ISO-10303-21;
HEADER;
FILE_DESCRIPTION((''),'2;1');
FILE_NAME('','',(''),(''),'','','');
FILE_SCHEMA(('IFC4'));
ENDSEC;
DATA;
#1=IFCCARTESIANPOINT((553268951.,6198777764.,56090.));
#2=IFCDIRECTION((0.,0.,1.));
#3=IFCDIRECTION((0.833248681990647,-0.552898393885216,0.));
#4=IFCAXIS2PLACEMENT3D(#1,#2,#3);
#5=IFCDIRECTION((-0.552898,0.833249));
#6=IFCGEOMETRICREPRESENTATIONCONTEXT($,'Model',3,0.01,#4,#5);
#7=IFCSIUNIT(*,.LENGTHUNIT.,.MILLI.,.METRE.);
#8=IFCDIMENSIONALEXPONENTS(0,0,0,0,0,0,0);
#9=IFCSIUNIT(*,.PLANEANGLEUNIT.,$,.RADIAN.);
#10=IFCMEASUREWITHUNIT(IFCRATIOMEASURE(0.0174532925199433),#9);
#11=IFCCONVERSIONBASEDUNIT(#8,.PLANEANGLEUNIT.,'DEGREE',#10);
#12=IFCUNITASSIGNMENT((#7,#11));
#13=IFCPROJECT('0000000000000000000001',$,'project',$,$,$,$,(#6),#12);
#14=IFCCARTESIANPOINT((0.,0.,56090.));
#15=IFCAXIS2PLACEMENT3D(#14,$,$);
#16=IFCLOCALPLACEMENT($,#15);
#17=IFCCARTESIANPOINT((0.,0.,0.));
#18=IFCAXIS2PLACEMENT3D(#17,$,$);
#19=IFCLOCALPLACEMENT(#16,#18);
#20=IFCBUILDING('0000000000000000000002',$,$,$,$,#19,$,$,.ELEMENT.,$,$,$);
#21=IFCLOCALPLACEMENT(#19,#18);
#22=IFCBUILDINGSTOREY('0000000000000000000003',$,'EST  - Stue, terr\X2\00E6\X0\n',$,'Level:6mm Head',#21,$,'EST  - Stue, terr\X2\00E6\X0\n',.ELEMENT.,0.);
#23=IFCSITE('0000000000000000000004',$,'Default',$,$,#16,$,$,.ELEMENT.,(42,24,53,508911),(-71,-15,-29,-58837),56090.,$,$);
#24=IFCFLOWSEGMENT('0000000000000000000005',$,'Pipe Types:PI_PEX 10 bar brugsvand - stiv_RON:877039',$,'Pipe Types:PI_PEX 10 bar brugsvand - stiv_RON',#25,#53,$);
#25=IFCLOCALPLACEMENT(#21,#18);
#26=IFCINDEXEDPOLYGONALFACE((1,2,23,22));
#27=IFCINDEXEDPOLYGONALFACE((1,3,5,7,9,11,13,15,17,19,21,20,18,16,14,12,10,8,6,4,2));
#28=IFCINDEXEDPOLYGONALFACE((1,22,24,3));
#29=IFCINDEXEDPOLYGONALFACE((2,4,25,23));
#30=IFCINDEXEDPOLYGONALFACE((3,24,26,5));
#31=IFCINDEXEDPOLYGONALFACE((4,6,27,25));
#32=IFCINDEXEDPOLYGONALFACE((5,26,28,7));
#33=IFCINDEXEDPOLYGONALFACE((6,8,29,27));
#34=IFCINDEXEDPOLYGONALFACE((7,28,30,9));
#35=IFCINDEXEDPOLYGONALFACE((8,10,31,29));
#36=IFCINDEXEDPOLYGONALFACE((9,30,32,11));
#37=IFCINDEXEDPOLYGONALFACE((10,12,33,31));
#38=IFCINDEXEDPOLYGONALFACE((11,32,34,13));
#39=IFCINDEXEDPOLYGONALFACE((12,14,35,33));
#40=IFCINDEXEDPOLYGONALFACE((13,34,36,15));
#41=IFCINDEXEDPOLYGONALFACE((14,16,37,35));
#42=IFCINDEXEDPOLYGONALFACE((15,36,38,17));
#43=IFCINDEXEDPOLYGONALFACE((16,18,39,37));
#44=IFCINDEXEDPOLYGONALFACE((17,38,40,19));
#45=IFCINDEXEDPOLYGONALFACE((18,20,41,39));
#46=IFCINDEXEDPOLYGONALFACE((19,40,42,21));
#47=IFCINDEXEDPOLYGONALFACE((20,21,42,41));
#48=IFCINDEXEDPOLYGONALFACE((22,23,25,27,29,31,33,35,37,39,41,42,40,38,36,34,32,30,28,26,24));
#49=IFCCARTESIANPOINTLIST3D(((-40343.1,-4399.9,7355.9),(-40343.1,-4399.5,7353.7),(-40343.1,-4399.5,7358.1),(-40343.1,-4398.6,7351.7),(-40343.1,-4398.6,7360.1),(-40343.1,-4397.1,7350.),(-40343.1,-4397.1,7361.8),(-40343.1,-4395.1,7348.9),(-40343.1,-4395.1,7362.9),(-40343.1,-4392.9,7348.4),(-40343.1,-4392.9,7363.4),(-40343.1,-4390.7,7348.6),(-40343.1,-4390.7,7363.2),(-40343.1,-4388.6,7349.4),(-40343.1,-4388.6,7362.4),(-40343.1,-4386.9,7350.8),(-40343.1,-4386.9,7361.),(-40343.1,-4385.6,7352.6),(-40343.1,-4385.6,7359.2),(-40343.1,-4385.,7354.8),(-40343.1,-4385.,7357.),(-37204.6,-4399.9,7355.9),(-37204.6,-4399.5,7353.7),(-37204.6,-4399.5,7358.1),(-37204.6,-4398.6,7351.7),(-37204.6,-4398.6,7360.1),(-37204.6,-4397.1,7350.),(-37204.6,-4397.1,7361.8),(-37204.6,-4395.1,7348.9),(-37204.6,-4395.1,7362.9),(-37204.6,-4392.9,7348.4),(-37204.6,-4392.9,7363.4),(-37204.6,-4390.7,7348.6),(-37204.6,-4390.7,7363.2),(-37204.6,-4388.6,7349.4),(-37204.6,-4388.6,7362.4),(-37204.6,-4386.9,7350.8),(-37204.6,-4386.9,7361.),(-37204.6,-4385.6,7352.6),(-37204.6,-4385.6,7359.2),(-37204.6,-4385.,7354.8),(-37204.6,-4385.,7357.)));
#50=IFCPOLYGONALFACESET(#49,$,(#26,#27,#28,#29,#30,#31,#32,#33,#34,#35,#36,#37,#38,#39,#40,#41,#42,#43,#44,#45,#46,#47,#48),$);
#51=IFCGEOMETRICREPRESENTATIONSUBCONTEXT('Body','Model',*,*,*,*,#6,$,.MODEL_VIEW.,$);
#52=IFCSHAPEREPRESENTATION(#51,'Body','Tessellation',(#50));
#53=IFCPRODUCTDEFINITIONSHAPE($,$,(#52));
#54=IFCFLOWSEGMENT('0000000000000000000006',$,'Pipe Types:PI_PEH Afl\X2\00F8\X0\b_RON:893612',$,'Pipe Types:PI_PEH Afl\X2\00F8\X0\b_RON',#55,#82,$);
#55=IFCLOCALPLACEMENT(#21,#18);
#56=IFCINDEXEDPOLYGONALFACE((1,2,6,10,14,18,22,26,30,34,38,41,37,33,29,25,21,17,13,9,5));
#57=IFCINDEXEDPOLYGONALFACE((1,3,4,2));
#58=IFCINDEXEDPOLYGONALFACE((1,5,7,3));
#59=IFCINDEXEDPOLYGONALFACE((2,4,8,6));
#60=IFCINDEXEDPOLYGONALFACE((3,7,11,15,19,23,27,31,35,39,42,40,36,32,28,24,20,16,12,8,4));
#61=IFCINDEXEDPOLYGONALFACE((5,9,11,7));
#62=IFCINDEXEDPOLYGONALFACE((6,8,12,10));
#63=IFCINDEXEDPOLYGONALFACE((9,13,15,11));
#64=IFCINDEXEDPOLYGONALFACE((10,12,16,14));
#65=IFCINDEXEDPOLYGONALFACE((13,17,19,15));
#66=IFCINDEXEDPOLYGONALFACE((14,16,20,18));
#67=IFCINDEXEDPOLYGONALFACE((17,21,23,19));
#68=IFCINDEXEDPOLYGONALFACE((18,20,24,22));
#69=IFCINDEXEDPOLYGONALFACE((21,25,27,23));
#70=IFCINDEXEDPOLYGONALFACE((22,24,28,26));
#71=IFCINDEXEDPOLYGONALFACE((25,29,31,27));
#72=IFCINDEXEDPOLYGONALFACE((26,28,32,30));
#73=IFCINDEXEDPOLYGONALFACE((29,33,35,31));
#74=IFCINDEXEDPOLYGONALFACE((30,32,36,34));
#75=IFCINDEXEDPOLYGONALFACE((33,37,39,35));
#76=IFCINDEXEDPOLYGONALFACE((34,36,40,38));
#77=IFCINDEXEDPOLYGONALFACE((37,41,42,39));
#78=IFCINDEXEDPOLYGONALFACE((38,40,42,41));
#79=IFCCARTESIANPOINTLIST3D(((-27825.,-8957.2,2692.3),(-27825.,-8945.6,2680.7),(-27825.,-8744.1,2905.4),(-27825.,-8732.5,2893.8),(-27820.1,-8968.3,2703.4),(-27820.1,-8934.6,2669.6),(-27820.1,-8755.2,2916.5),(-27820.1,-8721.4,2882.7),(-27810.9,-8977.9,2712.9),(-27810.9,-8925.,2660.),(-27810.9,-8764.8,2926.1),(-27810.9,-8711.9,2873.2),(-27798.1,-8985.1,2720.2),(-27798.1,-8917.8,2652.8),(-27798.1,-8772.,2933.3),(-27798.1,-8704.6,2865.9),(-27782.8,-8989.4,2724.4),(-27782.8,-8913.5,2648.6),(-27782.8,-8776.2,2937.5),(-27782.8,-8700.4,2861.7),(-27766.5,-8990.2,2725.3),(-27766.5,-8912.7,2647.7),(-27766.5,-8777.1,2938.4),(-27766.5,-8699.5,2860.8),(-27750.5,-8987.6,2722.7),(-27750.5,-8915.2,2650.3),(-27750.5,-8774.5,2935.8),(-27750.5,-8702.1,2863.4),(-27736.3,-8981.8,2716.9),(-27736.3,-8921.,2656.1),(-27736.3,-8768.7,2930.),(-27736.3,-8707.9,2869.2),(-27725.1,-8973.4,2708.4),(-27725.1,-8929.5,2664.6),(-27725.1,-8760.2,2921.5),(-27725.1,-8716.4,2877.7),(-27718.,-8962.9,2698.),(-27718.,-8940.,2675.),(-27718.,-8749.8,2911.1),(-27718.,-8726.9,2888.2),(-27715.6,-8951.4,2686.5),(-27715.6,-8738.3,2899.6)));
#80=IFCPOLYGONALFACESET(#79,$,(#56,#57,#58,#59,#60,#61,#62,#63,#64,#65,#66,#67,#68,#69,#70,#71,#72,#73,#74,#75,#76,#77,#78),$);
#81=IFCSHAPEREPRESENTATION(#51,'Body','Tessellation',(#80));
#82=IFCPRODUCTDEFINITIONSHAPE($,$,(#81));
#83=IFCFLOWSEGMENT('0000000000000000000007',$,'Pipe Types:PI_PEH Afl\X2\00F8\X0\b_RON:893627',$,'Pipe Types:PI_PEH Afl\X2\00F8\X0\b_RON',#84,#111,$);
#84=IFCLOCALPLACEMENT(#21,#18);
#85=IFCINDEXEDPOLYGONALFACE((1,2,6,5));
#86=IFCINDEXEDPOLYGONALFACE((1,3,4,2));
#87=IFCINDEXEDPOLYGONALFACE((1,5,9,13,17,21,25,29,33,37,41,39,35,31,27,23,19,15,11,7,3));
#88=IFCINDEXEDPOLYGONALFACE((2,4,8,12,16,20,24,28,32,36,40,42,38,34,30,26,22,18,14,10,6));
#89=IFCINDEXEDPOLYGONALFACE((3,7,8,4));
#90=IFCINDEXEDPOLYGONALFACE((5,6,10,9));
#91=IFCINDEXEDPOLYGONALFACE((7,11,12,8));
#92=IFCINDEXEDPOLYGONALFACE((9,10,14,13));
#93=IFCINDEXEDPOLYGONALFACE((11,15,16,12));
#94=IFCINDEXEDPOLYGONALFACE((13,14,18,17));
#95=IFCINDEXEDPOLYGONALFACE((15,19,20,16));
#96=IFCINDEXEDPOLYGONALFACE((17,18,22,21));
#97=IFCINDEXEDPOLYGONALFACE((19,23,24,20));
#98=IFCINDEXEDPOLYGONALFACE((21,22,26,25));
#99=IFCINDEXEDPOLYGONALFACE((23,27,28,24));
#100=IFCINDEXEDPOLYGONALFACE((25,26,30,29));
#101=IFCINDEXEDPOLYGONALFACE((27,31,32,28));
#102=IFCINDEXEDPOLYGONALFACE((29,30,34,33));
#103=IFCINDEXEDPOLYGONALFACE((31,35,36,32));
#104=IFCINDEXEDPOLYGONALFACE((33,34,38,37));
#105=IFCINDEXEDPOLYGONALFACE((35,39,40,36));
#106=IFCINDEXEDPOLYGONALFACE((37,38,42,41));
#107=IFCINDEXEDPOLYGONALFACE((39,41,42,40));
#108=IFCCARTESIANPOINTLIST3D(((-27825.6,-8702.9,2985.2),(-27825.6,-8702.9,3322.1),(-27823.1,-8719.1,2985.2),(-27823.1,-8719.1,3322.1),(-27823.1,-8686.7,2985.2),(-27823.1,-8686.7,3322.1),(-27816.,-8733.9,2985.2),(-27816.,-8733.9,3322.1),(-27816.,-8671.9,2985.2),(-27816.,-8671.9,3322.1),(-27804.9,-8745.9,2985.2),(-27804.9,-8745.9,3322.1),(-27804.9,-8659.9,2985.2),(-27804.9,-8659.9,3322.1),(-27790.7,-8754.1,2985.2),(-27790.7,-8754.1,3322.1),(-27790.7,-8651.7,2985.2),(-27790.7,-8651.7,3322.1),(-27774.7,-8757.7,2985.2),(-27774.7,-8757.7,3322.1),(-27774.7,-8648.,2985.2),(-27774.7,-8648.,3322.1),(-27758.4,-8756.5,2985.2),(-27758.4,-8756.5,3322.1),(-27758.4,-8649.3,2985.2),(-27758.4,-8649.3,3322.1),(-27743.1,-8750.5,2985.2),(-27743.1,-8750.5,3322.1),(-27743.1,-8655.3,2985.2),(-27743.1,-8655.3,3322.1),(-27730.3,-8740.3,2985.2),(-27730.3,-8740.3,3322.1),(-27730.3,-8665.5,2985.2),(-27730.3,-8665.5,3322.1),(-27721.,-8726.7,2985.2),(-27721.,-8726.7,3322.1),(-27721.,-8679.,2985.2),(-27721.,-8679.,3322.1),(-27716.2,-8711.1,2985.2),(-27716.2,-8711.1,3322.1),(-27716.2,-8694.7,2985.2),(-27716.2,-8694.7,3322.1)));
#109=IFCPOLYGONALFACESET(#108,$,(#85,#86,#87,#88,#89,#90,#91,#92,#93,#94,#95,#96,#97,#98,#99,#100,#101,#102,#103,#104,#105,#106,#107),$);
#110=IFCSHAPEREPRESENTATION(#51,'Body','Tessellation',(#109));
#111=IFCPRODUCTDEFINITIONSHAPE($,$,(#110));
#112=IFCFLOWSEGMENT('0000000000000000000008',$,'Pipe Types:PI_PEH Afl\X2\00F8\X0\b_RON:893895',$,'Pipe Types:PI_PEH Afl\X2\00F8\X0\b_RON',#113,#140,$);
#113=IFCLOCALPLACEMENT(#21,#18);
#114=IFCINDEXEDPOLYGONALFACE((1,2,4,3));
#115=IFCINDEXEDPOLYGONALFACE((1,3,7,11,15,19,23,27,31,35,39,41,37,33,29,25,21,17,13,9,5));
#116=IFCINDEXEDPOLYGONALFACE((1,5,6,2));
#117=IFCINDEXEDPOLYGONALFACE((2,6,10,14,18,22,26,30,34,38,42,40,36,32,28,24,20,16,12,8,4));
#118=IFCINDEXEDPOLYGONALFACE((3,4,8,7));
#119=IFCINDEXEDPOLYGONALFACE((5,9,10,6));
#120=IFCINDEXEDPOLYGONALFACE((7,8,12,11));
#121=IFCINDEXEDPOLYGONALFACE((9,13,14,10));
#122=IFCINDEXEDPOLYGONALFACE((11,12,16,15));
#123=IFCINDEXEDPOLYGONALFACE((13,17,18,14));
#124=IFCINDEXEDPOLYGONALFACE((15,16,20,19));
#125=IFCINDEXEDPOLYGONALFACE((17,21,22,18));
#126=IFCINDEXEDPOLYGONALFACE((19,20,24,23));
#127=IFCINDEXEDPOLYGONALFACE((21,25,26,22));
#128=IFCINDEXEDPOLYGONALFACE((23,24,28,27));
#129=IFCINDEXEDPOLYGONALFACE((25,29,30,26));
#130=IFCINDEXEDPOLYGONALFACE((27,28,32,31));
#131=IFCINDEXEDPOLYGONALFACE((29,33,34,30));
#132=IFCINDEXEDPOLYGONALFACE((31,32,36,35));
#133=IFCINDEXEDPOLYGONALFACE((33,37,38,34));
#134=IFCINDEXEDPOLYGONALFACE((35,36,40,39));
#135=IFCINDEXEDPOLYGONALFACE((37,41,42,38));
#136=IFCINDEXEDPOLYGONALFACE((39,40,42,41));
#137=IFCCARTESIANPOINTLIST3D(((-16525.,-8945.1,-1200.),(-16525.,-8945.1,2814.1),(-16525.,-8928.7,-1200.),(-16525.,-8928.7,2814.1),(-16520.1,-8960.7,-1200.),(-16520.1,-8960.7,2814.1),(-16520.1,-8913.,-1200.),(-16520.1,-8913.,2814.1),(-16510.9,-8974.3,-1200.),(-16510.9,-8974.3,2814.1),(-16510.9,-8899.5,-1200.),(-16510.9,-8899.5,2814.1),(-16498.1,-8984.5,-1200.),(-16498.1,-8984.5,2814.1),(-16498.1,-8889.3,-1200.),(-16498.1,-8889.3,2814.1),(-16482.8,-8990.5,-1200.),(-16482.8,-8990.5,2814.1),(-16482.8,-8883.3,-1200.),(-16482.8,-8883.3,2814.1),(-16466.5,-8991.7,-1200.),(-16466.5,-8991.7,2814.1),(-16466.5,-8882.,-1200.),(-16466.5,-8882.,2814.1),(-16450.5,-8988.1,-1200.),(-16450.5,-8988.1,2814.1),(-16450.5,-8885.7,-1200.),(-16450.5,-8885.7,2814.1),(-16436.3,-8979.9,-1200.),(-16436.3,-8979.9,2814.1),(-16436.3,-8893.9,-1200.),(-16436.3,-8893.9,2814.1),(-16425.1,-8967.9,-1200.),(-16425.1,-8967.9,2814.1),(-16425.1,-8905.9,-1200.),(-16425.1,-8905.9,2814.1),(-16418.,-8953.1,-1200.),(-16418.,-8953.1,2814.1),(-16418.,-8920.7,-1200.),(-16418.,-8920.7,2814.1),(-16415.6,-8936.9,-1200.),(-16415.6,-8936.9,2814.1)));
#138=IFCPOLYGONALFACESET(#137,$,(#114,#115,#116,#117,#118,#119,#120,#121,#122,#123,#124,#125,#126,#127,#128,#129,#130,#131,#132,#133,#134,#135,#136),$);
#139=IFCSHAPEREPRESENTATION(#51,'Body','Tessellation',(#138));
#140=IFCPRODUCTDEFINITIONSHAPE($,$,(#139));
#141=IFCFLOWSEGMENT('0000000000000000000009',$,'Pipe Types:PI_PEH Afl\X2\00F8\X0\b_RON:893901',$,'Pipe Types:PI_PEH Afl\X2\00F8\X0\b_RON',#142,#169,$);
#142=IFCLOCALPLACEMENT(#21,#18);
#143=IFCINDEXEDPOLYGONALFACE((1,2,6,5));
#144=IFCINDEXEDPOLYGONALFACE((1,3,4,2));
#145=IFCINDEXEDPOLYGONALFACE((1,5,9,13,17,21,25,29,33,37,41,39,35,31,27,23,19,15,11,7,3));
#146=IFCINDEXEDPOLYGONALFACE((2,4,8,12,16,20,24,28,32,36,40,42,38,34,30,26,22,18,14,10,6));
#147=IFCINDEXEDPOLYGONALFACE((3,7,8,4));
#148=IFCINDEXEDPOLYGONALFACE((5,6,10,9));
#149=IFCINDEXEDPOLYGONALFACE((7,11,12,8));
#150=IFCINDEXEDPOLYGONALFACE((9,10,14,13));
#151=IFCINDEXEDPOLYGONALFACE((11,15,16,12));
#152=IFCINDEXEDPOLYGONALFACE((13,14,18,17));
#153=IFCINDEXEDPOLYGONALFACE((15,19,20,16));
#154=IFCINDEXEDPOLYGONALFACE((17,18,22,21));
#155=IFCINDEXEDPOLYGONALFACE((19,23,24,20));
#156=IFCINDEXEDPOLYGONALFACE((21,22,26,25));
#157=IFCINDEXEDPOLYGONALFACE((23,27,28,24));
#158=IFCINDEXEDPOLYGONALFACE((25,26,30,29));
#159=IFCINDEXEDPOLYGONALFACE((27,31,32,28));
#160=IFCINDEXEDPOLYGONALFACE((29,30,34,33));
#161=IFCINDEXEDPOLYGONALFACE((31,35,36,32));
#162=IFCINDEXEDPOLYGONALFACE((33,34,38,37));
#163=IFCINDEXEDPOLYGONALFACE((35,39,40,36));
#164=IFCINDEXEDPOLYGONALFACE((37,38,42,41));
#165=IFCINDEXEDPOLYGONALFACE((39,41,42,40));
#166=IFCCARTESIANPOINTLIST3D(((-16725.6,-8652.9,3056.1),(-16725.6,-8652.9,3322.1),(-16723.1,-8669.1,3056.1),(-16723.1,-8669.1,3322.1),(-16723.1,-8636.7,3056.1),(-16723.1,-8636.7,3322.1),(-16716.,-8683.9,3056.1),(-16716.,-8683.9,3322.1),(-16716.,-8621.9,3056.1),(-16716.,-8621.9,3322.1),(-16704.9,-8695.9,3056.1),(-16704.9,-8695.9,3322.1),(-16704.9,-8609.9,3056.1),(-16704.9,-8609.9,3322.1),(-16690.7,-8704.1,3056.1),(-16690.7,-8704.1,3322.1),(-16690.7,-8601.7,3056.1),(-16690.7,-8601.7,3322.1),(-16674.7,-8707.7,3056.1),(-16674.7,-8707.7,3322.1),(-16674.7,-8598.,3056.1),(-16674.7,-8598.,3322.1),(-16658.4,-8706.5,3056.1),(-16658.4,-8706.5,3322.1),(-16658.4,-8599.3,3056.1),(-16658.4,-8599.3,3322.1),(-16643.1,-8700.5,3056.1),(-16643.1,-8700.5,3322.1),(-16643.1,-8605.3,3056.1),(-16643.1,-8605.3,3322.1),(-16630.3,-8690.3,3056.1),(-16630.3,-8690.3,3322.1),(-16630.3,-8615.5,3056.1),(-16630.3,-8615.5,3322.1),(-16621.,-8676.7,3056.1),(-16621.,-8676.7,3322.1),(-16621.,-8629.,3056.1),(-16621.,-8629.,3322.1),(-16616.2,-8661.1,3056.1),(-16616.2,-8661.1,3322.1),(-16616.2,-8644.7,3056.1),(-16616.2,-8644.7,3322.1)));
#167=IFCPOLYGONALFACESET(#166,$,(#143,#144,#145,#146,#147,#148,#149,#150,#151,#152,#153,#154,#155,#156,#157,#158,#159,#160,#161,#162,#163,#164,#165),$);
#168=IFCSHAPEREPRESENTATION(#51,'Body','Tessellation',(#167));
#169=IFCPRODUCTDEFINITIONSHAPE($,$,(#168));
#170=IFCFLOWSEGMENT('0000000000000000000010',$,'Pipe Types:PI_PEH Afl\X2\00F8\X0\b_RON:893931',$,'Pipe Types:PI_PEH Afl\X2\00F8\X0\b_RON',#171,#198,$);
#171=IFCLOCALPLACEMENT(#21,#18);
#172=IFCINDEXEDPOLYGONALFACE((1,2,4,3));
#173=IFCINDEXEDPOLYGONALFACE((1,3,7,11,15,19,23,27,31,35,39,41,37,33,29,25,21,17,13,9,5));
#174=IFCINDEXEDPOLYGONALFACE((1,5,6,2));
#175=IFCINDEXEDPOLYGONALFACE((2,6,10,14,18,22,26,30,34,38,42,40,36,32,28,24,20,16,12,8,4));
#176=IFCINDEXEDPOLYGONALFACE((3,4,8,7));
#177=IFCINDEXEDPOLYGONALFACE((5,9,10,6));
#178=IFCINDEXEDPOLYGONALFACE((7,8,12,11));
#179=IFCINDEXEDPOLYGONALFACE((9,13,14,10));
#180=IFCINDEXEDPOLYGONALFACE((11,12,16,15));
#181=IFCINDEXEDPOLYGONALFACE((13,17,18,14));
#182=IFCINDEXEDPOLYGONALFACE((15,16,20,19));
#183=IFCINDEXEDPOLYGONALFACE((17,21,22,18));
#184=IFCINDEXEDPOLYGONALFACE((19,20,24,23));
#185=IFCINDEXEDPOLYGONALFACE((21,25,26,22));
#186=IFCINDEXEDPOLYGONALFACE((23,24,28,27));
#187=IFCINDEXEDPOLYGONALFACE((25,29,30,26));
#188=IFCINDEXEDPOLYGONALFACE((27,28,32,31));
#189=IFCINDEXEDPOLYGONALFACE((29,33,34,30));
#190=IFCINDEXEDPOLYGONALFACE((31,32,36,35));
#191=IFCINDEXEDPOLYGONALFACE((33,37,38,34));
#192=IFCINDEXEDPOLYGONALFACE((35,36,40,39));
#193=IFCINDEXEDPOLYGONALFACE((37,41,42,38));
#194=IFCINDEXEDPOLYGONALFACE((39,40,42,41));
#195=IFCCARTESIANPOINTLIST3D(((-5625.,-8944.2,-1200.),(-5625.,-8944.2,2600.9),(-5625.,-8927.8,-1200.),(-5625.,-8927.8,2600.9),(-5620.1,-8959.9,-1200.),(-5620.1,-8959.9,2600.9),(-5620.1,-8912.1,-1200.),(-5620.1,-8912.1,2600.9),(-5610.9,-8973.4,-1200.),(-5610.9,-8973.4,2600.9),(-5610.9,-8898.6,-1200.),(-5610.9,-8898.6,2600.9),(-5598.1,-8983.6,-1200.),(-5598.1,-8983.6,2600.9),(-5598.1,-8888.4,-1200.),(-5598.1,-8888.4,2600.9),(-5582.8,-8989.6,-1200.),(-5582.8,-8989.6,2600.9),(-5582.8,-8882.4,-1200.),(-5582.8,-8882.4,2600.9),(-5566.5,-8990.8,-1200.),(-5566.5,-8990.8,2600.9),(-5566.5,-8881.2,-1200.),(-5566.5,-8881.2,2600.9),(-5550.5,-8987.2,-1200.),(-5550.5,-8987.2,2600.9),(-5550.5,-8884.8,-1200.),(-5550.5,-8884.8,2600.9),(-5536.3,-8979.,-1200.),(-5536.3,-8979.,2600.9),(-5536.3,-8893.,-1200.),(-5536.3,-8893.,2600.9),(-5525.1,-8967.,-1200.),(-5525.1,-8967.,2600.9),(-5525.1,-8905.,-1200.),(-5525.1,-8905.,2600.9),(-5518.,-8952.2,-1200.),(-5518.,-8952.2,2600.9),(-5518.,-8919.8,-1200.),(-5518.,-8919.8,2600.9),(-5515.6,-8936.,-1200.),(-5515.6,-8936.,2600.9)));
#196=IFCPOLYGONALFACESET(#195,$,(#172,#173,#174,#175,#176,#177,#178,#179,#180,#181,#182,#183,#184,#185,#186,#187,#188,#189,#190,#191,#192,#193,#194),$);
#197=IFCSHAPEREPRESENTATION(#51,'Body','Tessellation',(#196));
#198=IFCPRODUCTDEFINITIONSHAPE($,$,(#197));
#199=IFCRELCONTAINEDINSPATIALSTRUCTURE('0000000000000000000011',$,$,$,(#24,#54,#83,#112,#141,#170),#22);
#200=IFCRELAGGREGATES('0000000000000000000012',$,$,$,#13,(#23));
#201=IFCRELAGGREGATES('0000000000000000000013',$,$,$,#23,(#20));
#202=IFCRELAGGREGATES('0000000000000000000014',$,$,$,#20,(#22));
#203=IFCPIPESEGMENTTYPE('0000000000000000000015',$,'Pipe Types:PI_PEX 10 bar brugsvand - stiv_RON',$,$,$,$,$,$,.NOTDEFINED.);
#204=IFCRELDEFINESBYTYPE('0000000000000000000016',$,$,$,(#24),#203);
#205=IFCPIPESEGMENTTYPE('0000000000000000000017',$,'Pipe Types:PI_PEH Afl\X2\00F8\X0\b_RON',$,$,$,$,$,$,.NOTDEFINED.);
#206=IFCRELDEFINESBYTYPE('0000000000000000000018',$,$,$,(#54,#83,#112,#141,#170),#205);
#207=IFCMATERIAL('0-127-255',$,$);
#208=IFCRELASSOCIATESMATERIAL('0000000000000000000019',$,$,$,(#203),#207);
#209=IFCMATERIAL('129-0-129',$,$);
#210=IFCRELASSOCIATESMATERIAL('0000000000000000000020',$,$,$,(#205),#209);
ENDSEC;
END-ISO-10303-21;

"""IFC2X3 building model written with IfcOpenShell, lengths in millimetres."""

from ifc_helpers import new_model, entity, si_unit, converted_unit, direction, frame, frame_2d, origin, origin_2d_with_axis, place, context, subcontext, project, spatial, circle, extrude, material, type_object, element, save


model = new_model("IFC2X3")

# Units and contexts
model_context = context("Model", 3, precision=0.01, world=frame((553268951.0, 6198777764.0, 56090.0), z_axis=(0.0, 0.0, 1.0), x_axis=(0.833248681990647, -0.552898393885216, 0.0)), true_north=direction((-0.552898, 0.833249)))
body_context = subcontext(model_context, "Body", "Model", "MODEL_VIEW")
ifc_project = project(units=[si_unit("LENGTHUNIT", "METRE", prefix="MILLI"), converted_unit("PLANEANGLEUNIT", "DEGREE", entity("IfcRatioMeasure", 0.0174532925199433), si_unit("PLANEANGLEUNIT", "RADIAN"), dimensions=[0, 0, 0, 0, 0, 0, 0])], contexts=[model_context])

# Site, building, storey
site_placement = place(None, frame((0.0, 0.0, 56090.0)))
site = spatial("IfcSite", under=ifc_project, at=site_placement, Name="Default", CompositionType="ELEMENT", RefLatitude=(42, 24, 53, 508911), RefLongitude=(-71, -15, -29, -58837), RefElevation=56090.0)
building_placement = place(site_placement, origin())
building = spatial("IfcBuilding", under=site, at=building_placement, CompositionType="ELEMENT")
storey_placement = place(building_placement, frame((0.0, 0.0, 0.0)))
storey = spatial("IfcBuildingStorey", under=building, at=storey_placement, Name="EST  - Stue, terræn", ObjectType="Level:6mm Head", LongName="EST  - Stue, terræn", CompositionType="ELEMENT", Elevation=0.0)

# Flow segments
ifc_material_1 = material(Name="0-127-255")
pipe_segment_type_1 = type_object("IfcPipeSegmentType", Name="Pipe Types:PI_PEX 10 bar brugsvand - stiv_RON", PredefinedType="NOTDEFINED", material=ifc_material_1)
flow_segment_1_placement = place(storey_placement, origin())
element("IfcFlowSegment", 1, at=flow_segment_1_placement, inside=storey, type_object=pipe_segment_type_1, Name="Pipe Types:PI_PEX 10 bar brugsvand - stiv_RON:877039", ObjectType="Pipe Types:PI_PEX 10 bar brugsvand - stiv_RON", context=body_context, shape_type="SweptSolid", body=[
    extrude(circle(Radius=7.5, at=origin_2d_with_axis()), frame((-40343.1, -4392.4, 7355.9), z_axis=(1.0, 0.0, 0.0), x_axis=(0.0, -1.0, 0.0)), (0.0, 0.0, 1.0), 3138.5),
])
ifc_material_2 = material(Name="129-0-129")
pipe_segment_type_2 = type_object("IfcPipeSegmentType", Name="Pipe Types:PI_PEH Afløb_RON", PredefinedType="NOTDEFINED", material=ifc_material_2)
flow_segment_2_placement = place(storey_placement, origin())
element("IfcFlowSegment", 2, at=flow_segment_2_placement, inside=storey, type_object=pipe_segment_type_2, Name="Pipe Types:PI_PEH Afløb_RON:893612", ObjectType="Pipe Types:PI_PEH Afløb_RON", context=body_context, shape_type="SweptSolid", body=[
    extrude(circle(Radius=55.0, at=frame_2d((0.0, 0.0), x_axis=(1.0, 0.0))), frame((-27770.6, -8951.4, 2686.5), z_axis=(0.0, 0.707107, 0.707107), x_axis=(1.0, 0.0, 0.0)), (0.0, 0.0, 1.0), 301.4),
])
flow_segment_3_placement = place(storey_placement, origin())
element("IfcFlowSegment", 3, at=flow_segment_3_placement, inside=storey, type_object=pipe_segment_type_2, Name="Pipe Types:PI_PEH Afløb_RON:893627", ObjectType="Pipe Types:PI_PEH Afløb_RON", context=body_context, shape_type="SweptSolid", body=[
    extrude(circle(Radius=55.0, at=origin_2d_with_axis()), frame((-27770.6, -8702.9, 2985.2), z_axis=(0.0, 0.0, 1.0), x_axis=(-1.0, 0.0, 0.0)), (0.0, 0.0, 1.0), 336.9),
])
flow_segment_4_placement = place(storey_placement, origin())
element("IfcFlowSegment", 4, at=flow_segment_4_placement, inside=storey, type_object=pipe_segment_type_2, Name="Pipe Types:PI_PEH Afløb_RON:893895", ObjectType="Pipe Types:PI_PEH Afløb_RON", context=body_context, shape_type="SweptSolid", body=[
    extrude(circle(Radius=55.0, at=origin_2d_with_axis()), frame((-16470.6, -8936.9, -1200.0)), (0.0, 0.0, 1.0), 4014.1),
])
flow_segment_5_placement = place(storey_placement, origin())
element("IfcFlowSegment", 5, at=flow_segment_5_placement, inside=storey, type_object=pipe_segment_type_2, Name="Pipe Types:PI_PEH Afløb_RON:893901", ObjectType="Pipe Types:PI_PEH Afløb_RON", context=body_context, shape_type="SweptSolid", body=[
    extrude(circle(Radius=55.0, at=frame_2d((0.0, 0.0), x_axis=(1.0, 0.0))), frame((-16670.6, -8652.9, 3056.1), z_axis=(0.0, 0.0, 1.0), x_axis=(-1.0, 0.0, 0.0)), (0.0, 0.0, 1.0), 266.0),
])
flow_segment_6_placement = place(storey_placement, origin())
element("IfcFlowSegment", 6, at=flow_segment_6_placement, inside=storey, type_object=pipe_segment_type_2, Name="Pipe Types:PI_PEH Afløb_RON:893931", ObjectType="Pipe Types:PI_PEH Afløb_RON", context=body_context, shape_type="SweptSolid", body=[
    extrude(circle(Radius=55.0, at=origin_2d_with_axis()), frame((-5570.6, -8936.0, -1200.0)), (0.0, 0.0, 1.0), 3800.9),
])

save(model, "model.ifc")
